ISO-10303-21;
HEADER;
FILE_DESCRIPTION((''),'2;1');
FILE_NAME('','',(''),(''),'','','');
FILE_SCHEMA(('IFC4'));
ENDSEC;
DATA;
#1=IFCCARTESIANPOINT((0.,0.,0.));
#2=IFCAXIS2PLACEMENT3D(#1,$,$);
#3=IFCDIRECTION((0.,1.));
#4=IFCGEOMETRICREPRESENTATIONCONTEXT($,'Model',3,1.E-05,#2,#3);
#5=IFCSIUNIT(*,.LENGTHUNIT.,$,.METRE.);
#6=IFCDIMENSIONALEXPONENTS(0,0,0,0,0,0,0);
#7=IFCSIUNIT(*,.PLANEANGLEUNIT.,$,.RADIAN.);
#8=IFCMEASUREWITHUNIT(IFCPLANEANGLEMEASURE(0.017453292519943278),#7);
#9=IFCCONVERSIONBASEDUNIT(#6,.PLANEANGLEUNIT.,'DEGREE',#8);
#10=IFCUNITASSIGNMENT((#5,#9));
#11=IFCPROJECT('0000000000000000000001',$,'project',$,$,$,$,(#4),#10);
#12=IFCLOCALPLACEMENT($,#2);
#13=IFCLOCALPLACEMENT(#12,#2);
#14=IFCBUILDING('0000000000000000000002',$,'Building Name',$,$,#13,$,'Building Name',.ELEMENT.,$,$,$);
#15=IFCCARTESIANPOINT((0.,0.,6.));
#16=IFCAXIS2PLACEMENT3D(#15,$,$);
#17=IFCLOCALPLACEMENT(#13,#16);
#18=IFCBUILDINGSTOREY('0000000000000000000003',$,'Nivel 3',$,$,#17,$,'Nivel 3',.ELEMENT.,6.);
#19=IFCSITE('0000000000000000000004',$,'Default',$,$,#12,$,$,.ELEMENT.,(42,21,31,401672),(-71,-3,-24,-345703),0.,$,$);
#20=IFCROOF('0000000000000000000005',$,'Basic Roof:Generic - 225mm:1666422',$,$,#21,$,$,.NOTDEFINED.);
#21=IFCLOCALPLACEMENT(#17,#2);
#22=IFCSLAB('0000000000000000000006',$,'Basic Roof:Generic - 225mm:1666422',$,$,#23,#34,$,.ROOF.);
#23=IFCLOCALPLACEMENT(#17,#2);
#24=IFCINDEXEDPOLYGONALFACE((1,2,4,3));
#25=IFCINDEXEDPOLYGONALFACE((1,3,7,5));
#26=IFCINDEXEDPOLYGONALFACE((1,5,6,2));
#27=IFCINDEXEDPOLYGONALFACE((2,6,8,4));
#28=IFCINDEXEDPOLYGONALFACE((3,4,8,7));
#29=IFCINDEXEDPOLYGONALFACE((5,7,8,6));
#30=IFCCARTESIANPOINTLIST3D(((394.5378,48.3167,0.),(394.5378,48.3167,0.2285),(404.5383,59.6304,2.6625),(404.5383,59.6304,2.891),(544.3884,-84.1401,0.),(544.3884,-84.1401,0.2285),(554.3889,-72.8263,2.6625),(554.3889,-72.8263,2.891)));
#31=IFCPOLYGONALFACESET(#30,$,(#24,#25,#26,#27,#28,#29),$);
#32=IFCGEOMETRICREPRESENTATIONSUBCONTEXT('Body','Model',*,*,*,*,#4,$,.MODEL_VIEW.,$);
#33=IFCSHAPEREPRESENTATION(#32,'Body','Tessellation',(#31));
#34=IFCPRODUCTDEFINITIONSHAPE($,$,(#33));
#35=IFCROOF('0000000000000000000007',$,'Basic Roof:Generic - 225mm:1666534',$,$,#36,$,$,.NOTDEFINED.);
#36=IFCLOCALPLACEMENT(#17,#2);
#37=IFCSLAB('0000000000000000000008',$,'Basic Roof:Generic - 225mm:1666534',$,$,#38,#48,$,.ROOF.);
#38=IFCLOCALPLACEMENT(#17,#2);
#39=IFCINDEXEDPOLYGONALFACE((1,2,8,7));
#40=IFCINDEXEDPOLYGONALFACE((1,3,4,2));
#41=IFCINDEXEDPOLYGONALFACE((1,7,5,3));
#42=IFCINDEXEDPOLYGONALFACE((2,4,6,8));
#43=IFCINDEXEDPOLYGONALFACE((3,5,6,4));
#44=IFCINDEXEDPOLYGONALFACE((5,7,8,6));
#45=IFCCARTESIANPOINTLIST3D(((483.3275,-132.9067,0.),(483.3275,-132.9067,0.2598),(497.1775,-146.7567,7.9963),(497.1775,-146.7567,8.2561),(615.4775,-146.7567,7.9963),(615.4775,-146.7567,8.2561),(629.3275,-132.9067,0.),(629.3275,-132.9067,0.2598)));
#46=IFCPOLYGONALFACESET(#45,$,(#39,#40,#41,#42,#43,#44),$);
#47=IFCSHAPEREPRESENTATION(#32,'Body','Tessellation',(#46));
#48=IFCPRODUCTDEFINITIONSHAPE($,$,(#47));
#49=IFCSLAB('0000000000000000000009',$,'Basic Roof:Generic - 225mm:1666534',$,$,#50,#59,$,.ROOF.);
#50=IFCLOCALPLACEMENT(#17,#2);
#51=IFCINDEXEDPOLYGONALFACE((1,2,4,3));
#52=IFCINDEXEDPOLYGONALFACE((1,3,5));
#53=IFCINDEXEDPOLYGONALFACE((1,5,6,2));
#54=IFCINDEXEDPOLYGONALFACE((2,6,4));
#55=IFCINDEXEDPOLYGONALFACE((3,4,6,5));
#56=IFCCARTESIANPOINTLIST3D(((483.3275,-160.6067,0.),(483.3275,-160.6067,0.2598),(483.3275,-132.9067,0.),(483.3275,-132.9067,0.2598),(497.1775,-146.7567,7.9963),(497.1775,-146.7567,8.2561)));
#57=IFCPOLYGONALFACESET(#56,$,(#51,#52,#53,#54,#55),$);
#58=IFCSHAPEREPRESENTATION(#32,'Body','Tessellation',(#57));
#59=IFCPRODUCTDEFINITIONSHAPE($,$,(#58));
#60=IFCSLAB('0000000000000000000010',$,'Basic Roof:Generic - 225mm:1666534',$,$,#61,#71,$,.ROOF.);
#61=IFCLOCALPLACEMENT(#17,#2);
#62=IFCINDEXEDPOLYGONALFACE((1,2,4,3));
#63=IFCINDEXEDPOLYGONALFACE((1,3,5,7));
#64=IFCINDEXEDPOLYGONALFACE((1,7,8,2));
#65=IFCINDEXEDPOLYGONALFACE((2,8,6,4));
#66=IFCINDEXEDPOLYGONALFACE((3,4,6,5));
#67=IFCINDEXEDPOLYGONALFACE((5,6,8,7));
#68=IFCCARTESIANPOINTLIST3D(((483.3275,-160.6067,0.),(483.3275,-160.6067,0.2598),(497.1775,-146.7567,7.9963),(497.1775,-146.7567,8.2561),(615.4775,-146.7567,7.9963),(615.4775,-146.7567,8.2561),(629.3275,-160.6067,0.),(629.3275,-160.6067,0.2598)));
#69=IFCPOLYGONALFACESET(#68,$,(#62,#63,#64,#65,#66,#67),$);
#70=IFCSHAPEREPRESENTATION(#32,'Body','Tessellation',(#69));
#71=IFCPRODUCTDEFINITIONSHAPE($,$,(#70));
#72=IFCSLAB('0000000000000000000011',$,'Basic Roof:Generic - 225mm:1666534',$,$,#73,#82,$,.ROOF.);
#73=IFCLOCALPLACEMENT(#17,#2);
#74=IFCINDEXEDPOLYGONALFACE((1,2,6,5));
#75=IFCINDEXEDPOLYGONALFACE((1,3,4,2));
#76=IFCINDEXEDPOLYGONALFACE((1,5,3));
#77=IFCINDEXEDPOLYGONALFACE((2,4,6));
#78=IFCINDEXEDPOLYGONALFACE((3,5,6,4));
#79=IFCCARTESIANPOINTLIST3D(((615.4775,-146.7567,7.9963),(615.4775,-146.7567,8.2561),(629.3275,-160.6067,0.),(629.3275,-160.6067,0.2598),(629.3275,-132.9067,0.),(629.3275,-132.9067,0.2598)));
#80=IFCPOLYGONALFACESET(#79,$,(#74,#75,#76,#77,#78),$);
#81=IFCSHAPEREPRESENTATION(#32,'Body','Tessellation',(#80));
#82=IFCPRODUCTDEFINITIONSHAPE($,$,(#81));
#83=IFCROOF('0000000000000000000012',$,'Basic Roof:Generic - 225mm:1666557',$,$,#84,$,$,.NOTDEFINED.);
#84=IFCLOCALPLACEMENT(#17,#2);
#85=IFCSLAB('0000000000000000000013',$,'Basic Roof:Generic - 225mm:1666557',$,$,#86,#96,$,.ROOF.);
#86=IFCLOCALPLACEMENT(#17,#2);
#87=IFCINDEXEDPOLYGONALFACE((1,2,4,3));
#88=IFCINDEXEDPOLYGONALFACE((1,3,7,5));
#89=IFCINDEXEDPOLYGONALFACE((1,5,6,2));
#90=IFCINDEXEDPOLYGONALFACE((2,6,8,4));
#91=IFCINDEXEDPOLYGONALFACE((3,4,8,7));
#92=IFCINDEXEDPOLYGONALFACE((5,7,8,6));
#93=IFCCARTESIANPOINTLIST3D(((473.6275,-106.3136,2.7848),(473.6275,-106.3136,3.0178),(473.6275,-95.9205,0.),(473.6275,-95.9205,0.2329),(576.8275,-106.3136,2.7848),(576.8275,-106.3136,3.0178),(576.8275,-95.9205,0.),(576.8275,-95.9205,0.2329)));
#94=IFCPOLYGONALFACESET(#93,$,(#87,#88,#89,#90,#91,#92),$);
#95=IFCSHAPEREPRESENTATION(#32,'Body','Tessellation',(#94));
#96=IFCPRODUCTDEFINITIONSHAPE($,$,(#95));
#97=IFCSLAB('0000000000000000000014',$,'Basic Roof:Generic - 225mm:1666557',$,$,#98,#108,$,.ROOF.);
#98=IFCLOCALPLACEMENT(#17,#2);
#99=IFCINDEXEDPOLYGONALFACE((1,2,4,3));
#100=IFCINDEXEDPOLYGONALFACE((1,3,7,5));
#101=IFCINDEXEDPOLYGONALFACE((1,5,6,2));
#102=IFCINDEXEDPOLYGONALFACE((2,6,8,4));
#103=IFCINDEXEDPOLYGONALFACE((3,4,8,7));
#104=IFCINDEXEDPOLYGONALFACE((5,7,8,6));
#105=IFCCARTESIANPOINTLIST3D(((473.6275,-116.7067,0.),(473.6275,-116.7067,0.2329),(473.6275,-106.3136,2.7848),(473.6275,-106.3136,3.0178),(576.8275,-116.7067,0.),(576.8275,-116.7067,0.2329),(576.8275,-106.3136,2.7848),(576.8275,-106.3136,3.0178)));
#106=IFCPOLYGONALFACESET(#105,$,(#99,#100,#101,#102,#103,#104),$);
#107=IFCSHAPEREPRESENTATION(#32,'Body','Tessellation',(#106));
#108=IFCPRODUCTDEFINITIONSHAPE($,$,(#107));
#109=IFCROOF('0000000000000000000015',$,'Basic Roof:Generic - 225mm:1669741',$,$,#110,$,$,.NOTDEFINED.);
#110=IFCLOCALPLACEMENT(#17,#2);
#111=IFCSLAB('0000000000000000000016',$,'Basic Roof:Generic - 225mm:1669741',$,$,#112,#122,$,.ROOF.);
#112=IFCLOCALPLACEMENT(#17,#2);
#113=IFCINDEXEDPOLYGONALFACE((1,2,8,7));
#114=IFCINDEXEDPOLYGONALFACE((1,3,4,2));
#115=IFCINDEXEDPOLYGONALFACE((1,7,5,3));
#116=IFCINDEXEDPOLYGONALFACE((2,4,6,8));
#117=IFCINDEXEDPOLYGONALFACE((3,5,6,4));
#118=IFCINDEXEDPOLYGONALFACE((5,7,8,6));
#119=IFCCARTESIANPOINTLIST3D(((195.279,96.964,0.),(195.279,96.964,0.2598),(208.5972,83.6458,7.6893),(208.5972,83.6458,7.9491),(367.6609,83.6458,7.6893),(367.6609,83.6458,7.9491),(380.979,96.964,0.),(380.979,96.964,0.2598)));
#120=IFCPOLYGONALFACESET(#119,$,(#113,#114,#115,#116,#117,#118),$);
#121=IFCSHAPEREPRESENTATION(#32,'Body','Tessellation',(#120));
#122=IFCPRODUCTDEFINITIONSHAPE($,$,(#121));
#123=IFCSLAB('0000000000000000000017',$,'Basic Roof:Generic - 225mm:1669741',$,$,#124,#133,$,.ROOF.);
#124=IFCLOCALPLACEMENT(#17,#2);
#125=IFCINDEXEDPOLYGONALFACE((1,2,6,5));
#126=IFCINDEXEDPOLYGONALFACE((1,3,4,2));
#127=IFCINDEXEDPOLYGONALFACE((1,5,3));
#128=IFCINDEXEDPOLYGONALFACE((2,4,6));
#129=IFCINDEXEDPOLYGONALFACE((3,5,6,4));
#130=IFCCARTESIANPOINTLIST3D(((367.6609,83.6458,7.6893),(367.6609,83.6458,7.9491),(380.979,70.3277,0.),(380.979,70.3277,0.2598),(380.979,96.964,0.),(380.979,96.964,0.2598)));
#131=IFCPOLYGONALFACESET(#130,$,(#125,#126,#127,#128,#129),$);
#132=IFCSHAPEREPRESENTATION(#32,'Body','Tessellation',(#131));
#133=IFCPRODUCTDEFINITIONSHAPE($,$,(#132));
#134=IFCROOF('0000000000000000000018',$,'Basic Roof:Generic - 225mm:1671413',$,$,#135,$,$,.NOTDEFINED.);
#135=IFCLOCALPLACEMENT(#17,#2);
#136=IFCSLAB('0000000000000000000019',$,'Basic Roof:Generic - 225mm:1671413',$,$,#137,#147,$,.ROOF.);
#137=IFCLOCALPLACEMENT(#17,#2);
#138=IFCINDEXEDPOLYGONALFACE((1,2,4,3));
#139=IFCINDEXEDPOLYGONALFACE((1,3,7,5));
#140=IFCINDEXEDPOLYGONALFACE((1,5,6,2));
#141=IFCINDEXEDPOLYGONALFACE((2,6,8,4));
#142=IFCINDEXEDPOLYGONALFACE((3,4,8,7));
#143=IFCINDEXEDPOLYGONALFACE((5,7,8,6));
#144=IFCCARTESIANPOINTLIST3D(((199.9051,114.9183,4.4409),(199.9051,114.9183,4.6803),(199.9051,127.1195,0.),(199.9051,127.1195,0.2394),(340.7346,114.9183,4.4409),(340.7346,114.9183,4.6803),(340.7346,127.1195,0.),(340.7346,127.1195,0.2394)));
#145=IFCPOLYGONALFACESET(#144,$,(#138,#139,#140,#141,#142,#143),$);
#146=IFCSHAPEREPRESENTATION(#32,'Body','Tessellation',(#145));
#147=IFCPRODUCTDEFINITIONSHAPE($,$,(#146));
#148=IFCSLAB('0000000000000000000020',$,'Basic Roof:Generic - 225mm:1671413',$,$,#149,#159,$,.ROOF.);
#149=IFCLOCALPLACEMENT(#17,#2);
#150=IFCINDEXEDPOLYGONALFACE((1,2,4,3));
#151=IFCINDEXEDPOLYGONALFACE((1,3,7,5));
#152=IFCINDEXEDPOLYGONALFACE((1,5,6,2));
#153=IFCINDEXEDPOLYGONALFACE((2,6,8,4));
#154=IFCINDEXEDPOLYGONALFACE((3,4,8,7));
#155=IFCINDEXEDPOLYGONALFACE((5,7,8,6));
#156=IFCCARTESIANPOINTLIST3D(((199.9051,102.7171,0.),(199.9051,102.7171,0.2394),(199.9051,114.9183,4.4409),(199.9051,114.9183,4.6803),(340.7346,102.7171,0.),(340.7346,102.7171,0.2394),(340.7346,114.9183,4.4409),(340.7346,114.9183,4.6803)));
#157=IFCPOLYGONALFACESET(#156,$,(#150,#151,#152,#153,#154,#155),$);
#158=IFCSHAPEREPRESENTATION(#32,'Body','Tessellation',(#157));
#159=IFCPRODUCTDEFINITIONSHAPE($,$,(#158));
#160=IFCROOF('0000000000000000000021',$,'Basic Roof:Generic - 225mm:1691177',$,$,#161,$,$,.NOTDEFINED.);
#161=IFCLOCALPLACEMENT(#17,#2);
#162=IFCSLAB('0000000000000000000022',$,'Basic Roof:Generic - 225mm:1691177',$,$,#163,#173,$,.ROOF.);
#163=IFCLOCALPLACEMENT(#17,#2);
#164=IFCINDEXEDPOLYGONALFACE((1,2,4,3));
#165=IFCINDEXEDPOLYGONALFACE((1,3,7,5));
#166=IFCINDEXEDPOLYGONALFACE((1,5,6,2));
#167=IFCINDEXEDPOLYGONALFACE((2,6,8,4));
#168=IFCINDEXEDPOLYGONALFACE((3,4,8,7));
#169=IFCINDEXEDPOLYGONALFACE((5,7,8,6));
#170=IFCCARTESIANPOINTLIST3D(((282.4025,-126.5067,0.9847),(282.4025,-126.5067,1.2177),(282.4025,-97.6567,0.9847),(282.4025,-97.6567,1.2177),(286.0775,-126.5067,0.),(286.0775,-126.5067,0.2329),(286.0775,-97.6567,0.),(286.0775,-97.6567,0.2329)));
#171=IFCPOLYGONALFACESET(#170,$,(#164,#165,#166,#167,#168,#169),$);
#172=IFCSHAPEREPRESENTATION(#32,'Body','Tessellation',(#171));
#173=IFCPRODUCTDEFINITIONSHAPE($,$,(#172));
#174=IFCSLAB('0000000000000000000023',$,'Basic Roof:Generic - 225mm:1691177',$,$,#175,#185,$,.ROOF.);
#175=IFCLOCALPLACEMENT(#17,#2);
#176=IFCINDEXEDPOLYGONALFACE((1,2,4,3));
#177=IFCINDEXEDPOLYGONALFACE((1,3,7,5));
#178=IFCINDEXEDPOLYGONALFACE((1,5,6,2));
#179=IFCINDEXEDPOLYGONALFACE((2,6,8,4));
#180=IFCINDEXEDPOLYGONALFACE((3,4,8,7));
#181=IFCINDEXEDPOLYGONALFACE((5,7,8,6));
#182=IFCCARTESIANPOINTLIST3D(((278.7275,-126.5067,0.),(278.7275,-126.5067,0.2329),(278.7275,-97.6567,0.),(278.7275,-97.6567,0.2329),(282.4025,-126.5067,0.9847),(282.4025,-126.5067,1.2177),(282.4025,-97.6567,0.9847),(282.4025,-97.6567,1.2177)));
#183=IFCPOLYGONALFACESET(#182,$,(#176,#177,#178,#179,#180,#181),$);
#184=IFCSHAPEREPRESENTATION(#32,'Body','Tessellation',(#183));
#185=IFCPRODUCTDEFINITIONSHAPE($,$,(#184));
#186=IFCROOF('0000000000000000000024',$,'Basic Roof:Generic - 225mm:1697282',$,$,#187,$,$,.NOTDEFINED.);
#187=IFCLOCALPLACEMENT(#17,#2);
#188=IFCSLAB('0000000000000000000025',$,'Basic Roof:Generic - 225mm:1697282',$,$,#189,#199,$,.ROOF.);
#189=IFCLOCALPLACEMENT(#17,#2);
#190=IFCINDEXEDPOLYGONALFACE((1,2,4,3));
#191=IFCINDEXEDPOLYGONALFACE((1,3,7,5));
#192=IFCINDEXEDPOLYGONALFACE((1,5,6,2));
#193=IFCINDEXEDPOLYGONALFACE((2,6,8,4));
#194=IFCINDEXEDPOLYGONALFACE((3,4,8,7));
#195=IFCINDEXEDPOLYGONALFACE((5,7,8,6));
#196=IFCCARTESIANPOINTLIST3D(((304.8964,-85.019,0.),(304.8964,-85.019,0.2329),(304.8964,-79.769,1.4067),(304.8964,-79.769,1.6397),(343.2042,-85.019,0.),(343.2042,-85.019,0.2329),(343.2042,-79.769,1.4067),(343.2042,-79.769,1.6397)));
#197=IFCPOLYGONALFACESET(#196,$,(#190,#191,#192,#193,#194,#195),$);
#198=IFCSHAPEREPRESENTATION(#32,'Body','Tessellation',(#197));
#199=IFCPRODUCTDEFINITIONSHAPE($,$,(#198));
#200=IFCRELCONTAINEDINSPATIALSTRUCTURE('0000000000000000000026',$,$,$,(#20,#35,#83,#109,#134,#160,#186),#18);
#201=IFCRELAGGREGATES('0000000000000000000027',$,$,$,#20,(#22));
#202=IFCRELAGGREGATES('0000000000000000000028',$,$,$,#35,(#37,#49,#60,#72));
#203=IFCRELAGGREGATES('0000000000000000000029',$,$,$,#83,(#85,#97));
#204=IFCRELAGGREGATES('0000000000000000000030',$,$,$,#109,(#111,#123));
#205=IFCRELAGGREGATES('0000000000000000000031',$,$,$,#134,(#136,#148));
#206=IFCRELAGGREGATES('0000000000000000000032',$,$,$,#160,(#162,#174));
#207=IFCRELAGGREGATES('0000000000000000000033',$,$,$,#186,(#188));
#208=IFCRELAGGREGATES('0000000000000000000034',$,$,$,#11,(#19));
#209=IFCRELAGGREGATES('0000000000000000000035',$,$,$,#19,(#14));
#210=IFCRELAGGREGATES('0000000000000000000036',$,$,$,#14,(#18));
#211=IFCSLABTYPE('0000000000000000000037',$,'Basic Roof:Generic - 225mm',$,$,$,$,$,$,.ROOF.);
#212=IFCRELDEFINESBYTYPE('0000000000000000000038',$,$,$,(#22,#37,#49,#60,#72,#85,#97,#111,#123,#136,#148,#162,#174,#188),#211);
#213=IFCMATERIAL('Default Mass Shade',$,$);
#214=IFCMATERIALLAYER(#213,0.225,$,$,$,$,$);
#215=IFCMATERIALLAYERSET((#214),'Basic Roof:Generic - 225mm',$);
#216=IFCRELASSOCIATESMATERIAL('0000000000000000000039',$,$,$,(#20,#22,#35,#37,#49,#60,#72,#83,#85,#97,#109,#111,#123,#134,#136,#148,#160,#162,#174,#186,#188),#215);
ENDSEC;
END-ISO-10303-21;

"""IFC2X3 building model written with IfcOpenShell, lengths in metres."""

from ifc_helpers import new_model, entity, si_unit, converted_unit, direction, frame, frame_2d, origin, place, context, subcontext, project, spatial, polyline, rectangle, outline, extrude, material, layer, layer_set, type_object, element, aggregate, save


model = new_model("IFC2X3")

# Units and contexts
model_context = context("Model", 3, precision=1e-05, world=origin(), true_north=direction((0.0, 1.0)))
body_context = subcontext(model_context, "Body", "Model", "MODEL_VIEW")
ifc_project = project(units=[si_unit("LENGTHUNIT", "METRE"), converted_unit("PLANEANGLEUNIT", "DEGREE", entity("IfcPlaneAngleMeasure", 0.017453292519943278), si_unit("PLANEANGLEUNIT", "RADIAN"), dimensions=[0, 0, 0, 0, 0, 0, 0])], contexts=[model_context])

# Site, building, storey
site_placement = place(None, origin())
site = spatial("IfcSite", under=ifc_project, at=site_placement, Name="Default", CompositionType="ELEMENT", RefLatitude=(42, 21, 31, 401672), RefLongitude=(-71, -3, -24, -345703), RefElevation=0.0)
building_placement = place(site_placement, origin())
building = spatial("IfcBuilding", under=site, at=building_placement, Name="Building Name", LongName="Building Name", CompositionType="ELEMENT")
storey_placement = place(building_placement, frame((0.0, 0.0, 6.0)))
storey = spatial("IfcBuildingStorey", under=building, at=storey_placement, Name="Nivel 3", LongName="Nivel 3", CompositionType="ELEMENT", Elevation=6.0)

# Roofs, slabs
ifc_material = material(Name="Default Mass Shade")
ifc_layer = layer(ifc_material, 0.225)
ifc_layer_set = layer_set([ifc_layer], Name="Basic Roof:Generic - 225mm")
roof_1_placement = place(storey_placement, frame((394.5378, -84.1401, 0.0)))
roof_1 = element("IfcRoof", 1, at=roof_1_placement, inside=storey, material=ifc_layer_set, Name="Basic Roof:Generic - 225mm:1666422", ShapeType="NOTDEFINED")
slab_type = type_object("IfcSlabType", Name="Basic Roof:Generic - 225mm", PredefinedType="ROOF")
slab_1_placement = place(roof_1_placement, origin())
slab_1 = element("IfcSlab", 2, at=slab_1_placement, type_object=slab_type, material=ifc_layer_set, Name="Basic Roof:Generic - 225mm:1666422", PredefinedType="ROOF", context=body_context, shape_type="SweptSolid", body=[
    extrude(rectangle(XDim=15.333, YDim=200.0, at=frame_2d((0.0, 0.0), x_axis=(0.656579, 0.754258))), frame((79.9256, 71.8852, 1.3313), z_axis=(-0.115004, -0.130106, 0.984808), x_axis=(0.993365, -0.015063, 0.114014)), (0.114014, 0.130975, 0.984808), 0.2285),
])
aggregate(roof_1, [slab_1])
roof_2_placement = place(storey_placement, frame((483.3275, -160.6067, 0.0)))
roof_2 = element("IfcRoof", 3, at=roof_2_placement, inside=storey, material=ifc_layer_set, Name="Basic Roof:Generic - 225mm:1666534", ShapeType="NOTDEFINED")
slab_2_placement = place(roof_2_placement, origin())
slab_2 = element("IfcSlab", 4, at=slab_2_placement, type_object=slab_type, material=ifc_layer_set, Name="Basic Roof:Generic - 225mm:1666534", PredefinedType="ROOF", context=body_context, shape_type="SweptSolid", body=[
    extrude(outline(polyline([(73.0, 7.9963), (-73.0, 7.9963), (-59.15, -7.9963), (59.15, -7.9963), (73.0, 7.9963)])), frame((73.0, 20.775, 3.9982), z_axis=(0.0, 0.5, 0.866025), x_axis=(1.0, 0.0, 0.0)), (0.0, -0.5, 0.866025), 0.2598),
])
slab_3_placement = place(roof_2_placement, origin())
slab_3 = element("IfcSlab", 5, at=slab_3_placement, type_object=slab_type, material=ifc_layer_set, Name="Basic Roof:Generic - 225mm:1666534", PredefinedType="ROOF", context=body_context, shape_type="SweptSolid", body=[
    extrude(outline(polyline([(-7.9963, 13.85), (-7.9963, -13.85), (7.9963, 0.0), (-7.9963, 13.85)])), frame((6.925, 13.85, 3.9982), z_axis=(-0.5, 0.0, 0.866025), x_axis=(0.866025, 0.0, 0.5)), (0.5, 0.0, 0.866025), 0.2598),
])
slab_4_placement = place(roof_2_placement, origin())
slab_4 = element("IfcSlab", 6, at=slab_4_placement, type_object=slab_type, material=ifc_layer_set, Name="Basic Roof:Generic - 225mm:1666534", PredefinedType="ROOF", context=body_context, shape_type="SweptSolid", body=[
    extrude(outline(polyline([(-73.0, -7.9963), (73.0, -7.9963), (59.15, 7.9963), (-59.15, 7.9963), (-73.0, -7.9963)])), frame((73.0, 6.925, 3.9982), z_axis=(0.0, -0.5, 0.866025), x_axis=(1.0, 0.0, 0.0)), (0.0, 0.5, 0.866025), 0.2598),
])
slab_5_placement = place(roof_2_placement, origin())
slab_5 = element("IfcSlab", 7, at=slab_5_placement, type_object=slab_type, material=ifc_layer_set, Name="Basic Roof:Generic - 225mm:1666534", PredefinedType="ROOF", context=body_context, shape_type="SweptSolid", body=[
    extrude(outline(polyline([(-7.9963, 0.0), (7.9963, -13.85), (7.9963, 13.85), (-7.9963, 0.0)])), frame((139.075, 13.85, 3.9982), z_axis=(0.5, 0.0, 0.866025), x_axis=(0.866025, 0.0, -0.5)), (-0.5, 0.0, 0.866025), 0.2598),
])
aggregate(roof_2, [slab_2, slab_3, slab_4, slab_5])
roof_3_placement = place(storey_placement, frame((473.6275, -116.7067, 0.0)))
roof_3 = element("IfcRoof", 8, at=roof_3_placement, inside=storey, material=ifc_layer_set, Name="Basic Roof:Generic - 225mm:1666557", ShapeType="NOTDEFINED")
slab_6_placement = place(roof_3_placement, origin())
slab_6 = element("IfcSlab", 9, at=slab_6_placement, type_object=slab_type, material=ifc_layer_set, Name="Basic Roof:Generic - 225mm:1666557", PredefinedType="ROOF", context=body_context, shape_type="SweptSolid", body=[
    extrude(rectangle(XDim=103.2, YDim=10.7597, at=frame_2d((0.0, 0.0), x_axis=(1.0, 0.0))), frame((51.6, 15.5897, 1.3924), z_axis=(0.0, 0.258819, 0.965926), x_axis=(1.0, 0.0, 0.0)), (0.0, -0.258819, 0.965926), 0.2329),
])
slab_7_placement = place(roof_3_placement, origin())
slab_7 = element("IfcSlab", 10, at=slab_7_placement, type_object=slab_type, material=ifc_layer_set, Name="Basic Roof:Generic - 225mm:1666557", PredefinedType="ROOF", context=body_context, shape_type="SweptSolid", body=[
    extrude(rectangle(XDim=10.7597, YDim=103.2, at=frame_2d((0.0, 0.0), x_axis=(0.0, 1.0))), frame((51.6, 5.1966, 1.3924), z_axis=(0.0, -0.258819, 0.965926), x_axis=(1.0, 0.0, 0.0)), (0.0, 0.258819, 0.965926), 0.2329),
])
aggregate(roof_3, [slab_6, slab_7])
roof_4_placement = place(storey_placement, frame((195.279, 70.3277, 0.0)))
roof_4 = element("IfcRoof", 11, at=roof_4_placement, inside=storey, material=ifc_layer_set, Name="Basic Roof:Generic - 225mm:1669741", ShapeType="NOTDEFINED")
slab_8_placement = place(roof_4_placement, origin())
slab_8 = element("IfcSlab", 12, at=slab_8_placement, type_object=slab_type, material=ifc_layer_set, Name="Basic Roof:Generic - 225mm:1669741", PredefinedType="ROOF", context=body_context, shape_type="SweptSolid", body=[
    extrude(outline(polyline([(92.85, 7.6893), (-92.85, 7.6893), (-79.5318, -7.6893), (79.5318, -7.6893), (92.85, 7.6893)])), frame((92.85, 19.9773, 3.8446), z_axis=(0.0, 0.5, 0.866025), x_axis=(1.0, 0.0, 0.0)), (0.0, -0.5, 0.866025), 0.2598),
])
slab_9_placement = place(roof_4_placement, origin())
slab_9 = element("IfcSlab", 13, at=slab_9_placement, type_object=slab_type, material=ifc_layer_set, Name="Basic Roof:Generic - 225mm:1669741", PredefinedType="ROOF", context=body_context, shape_type="SweptSolid", body=[
    extrude(outline(polyline([(7.6893, -13.3182), (7.6893, 13.3182), (-7.6893, 0.0), (7.6893, -13.3182)])), frame((179.0409, 13.3182, 3.8446), z_axis=(0.5, 0.0, 0.866025), x_axis=(0.866025, 0.0, -0.5)), (-0.5, 0.0, 0.866025), 0.2598),
])
aggregate(roof_4, [slab_8, slab_9])
roof_5_placement = place(storey_placement, frame((199.9051, 102.7171, 0.0)))
roof_5 = element("IfcRoof", 14, at=roof_5_placement, inside=storey, material=ifc_layer_set, Name="Basic Roof:Generic - 225mm:1671413", ShapeType="NOTDEFINED")
slab_10_placement = place(roof_5_placement, origin())
slab_10 = element("IfcSlab", 15, at=slab_10_placement, type_object=slab_type, material=ifc_layer_set, Name="Basic Roof:Generic - 225mm:1671413", PredefinedType="ROOF", context=body_context, shape_type="SweptSolid", body=[
    extrude(rectangle(XDim=140.8295, YDim=12.9843, at=frame_2d((0.0, 0.0), x_axis=(1.0, 0.0))), frame((70.4148, 18.3018, 2.2204), z_axis=(0.0, 0.34202, 0.939693), x_axis=(1.0, 0.0, 0.0)), (0.0, -0.34202, 0.939693), 0.2394),
])
slab_11_placement = place(roof_5_placement, origin())
slab_11 = element("IfcSlab", 16, at=slab_11_placement, type_object=slab_type, material=ifc_layer_set, Name="Basic Roof:Generic - 225mm:1671413", PredefinedType="ROOF", context=body_context, shape_type="SweptSolid", body=[
    extrude(rectangle(XDim=12.9843, YDim=140.8295, at=frame_2d((0.0, 0.0), x_axis=(0.0, 1.0))), frame((70.4148, 6.1006, 2.2204), z_axis=(0.0, -0.34202, 0.939693), x_axis=(1.0, 0.0, 0.0)), (0.0, 0.34202, 0.939693), 0.2394),
])
aggregate(roof_5, [slab_10, slab_11])
roof_6_placement = place(storey_placement, frame((278.7275, -126.5067, 0.0)))
roof_6 = element("IfcRoof", 17, at=roof_6_placement, inside=storey, material=ifc_layer_set, Name="Basic Roof:Generic - 225mm:1691177", ShapeType="NOTDEFINED")
slab_12_placement = place(roof_6_placement, origin())
slab_12 = element("IfcSlab", 18, at=slab_12_placement, type_object=slab_type, material=ifc_layer_set, Name="Basic Roof:Generic - 225mm:1691177", PredefinedType="ROOF", context=body_context, shape_type="SweptSolid", body=[
    extrude(rectangle(XDim=28.85, YDim=3.8046, at=frame_2d((0.0, 0.0), x_axis=(0.0, -1.0))), frame((5.5125, 14.425, 0.4924), z_axis=(0.258819, 0.0, 0.965926), x_axis=(0.965926, 0.0, -0.258819)), (-0.258819, 0.0, 0.965926), 0.2329),
])
slab_13_placement = place(roof_6_placement, origin())
slab_13 = element("IfcSlab", 19, at=slab_13_placement, type_object=slab_type, material=ifc_layer_set, Name="Basic Roof:Generic - 225mm:1691177", PredefinedType="ROOF", context=body_context, shape_type="SweptSolid", body=[
    extrude(rectangle(XDim=3.8046, YDim=28.85, at=frame_2d((0.0, 0.0), x_axis=(-1.0, 0.0))), frame((1.8375, 14.425, 0.4924), z_axis=(-0.258819, 0.0, 0.965926), x_axis=(0.965926, 0.0, 0.258819)), (0.258819, 0.0, 0.965926), 0.2329),
])
aggregate(roof_6, [slab_12, slab_13])
roof_7_placement = place(storey_placement, frame((304.8964, -85.019, 0.0)))
roof_7 = element("IfcRoof", 20, at=roof_7_placement, inside=storey, material=ifc_layer_set, Name="Basic Roof:Generic - 225mm:1697282", ShapeType="NOTDEFINED")
slab_14_placement = place(roof_7_placement, origin())
slab_14 = element("IfcSlab", 21, at=slab_14_placement, type_object=slab_type, material=ifc_layer_set, Name="Basic Roof:Generic - 225mm:1697282", PredefinedType="ROOF", context=body_context, shape_type="SweptSolid", body=[
    extrude(rectangle(XDim=5.4352, YDim=38.3079, at=frame_2d((0.0, 0.0), x_axis=(0.0, 1.0))), frame((19.1539, 2.625, 0.7034), z_axis=(0.0, -0.258819, 0.965926), x_axis=(1.0, 0.0, 0.0)), (0.0, 0.258819, 0.965926), 0.2329),
])
aggregate(roof_7, [slab_14])

save(model, "model.ifc")
